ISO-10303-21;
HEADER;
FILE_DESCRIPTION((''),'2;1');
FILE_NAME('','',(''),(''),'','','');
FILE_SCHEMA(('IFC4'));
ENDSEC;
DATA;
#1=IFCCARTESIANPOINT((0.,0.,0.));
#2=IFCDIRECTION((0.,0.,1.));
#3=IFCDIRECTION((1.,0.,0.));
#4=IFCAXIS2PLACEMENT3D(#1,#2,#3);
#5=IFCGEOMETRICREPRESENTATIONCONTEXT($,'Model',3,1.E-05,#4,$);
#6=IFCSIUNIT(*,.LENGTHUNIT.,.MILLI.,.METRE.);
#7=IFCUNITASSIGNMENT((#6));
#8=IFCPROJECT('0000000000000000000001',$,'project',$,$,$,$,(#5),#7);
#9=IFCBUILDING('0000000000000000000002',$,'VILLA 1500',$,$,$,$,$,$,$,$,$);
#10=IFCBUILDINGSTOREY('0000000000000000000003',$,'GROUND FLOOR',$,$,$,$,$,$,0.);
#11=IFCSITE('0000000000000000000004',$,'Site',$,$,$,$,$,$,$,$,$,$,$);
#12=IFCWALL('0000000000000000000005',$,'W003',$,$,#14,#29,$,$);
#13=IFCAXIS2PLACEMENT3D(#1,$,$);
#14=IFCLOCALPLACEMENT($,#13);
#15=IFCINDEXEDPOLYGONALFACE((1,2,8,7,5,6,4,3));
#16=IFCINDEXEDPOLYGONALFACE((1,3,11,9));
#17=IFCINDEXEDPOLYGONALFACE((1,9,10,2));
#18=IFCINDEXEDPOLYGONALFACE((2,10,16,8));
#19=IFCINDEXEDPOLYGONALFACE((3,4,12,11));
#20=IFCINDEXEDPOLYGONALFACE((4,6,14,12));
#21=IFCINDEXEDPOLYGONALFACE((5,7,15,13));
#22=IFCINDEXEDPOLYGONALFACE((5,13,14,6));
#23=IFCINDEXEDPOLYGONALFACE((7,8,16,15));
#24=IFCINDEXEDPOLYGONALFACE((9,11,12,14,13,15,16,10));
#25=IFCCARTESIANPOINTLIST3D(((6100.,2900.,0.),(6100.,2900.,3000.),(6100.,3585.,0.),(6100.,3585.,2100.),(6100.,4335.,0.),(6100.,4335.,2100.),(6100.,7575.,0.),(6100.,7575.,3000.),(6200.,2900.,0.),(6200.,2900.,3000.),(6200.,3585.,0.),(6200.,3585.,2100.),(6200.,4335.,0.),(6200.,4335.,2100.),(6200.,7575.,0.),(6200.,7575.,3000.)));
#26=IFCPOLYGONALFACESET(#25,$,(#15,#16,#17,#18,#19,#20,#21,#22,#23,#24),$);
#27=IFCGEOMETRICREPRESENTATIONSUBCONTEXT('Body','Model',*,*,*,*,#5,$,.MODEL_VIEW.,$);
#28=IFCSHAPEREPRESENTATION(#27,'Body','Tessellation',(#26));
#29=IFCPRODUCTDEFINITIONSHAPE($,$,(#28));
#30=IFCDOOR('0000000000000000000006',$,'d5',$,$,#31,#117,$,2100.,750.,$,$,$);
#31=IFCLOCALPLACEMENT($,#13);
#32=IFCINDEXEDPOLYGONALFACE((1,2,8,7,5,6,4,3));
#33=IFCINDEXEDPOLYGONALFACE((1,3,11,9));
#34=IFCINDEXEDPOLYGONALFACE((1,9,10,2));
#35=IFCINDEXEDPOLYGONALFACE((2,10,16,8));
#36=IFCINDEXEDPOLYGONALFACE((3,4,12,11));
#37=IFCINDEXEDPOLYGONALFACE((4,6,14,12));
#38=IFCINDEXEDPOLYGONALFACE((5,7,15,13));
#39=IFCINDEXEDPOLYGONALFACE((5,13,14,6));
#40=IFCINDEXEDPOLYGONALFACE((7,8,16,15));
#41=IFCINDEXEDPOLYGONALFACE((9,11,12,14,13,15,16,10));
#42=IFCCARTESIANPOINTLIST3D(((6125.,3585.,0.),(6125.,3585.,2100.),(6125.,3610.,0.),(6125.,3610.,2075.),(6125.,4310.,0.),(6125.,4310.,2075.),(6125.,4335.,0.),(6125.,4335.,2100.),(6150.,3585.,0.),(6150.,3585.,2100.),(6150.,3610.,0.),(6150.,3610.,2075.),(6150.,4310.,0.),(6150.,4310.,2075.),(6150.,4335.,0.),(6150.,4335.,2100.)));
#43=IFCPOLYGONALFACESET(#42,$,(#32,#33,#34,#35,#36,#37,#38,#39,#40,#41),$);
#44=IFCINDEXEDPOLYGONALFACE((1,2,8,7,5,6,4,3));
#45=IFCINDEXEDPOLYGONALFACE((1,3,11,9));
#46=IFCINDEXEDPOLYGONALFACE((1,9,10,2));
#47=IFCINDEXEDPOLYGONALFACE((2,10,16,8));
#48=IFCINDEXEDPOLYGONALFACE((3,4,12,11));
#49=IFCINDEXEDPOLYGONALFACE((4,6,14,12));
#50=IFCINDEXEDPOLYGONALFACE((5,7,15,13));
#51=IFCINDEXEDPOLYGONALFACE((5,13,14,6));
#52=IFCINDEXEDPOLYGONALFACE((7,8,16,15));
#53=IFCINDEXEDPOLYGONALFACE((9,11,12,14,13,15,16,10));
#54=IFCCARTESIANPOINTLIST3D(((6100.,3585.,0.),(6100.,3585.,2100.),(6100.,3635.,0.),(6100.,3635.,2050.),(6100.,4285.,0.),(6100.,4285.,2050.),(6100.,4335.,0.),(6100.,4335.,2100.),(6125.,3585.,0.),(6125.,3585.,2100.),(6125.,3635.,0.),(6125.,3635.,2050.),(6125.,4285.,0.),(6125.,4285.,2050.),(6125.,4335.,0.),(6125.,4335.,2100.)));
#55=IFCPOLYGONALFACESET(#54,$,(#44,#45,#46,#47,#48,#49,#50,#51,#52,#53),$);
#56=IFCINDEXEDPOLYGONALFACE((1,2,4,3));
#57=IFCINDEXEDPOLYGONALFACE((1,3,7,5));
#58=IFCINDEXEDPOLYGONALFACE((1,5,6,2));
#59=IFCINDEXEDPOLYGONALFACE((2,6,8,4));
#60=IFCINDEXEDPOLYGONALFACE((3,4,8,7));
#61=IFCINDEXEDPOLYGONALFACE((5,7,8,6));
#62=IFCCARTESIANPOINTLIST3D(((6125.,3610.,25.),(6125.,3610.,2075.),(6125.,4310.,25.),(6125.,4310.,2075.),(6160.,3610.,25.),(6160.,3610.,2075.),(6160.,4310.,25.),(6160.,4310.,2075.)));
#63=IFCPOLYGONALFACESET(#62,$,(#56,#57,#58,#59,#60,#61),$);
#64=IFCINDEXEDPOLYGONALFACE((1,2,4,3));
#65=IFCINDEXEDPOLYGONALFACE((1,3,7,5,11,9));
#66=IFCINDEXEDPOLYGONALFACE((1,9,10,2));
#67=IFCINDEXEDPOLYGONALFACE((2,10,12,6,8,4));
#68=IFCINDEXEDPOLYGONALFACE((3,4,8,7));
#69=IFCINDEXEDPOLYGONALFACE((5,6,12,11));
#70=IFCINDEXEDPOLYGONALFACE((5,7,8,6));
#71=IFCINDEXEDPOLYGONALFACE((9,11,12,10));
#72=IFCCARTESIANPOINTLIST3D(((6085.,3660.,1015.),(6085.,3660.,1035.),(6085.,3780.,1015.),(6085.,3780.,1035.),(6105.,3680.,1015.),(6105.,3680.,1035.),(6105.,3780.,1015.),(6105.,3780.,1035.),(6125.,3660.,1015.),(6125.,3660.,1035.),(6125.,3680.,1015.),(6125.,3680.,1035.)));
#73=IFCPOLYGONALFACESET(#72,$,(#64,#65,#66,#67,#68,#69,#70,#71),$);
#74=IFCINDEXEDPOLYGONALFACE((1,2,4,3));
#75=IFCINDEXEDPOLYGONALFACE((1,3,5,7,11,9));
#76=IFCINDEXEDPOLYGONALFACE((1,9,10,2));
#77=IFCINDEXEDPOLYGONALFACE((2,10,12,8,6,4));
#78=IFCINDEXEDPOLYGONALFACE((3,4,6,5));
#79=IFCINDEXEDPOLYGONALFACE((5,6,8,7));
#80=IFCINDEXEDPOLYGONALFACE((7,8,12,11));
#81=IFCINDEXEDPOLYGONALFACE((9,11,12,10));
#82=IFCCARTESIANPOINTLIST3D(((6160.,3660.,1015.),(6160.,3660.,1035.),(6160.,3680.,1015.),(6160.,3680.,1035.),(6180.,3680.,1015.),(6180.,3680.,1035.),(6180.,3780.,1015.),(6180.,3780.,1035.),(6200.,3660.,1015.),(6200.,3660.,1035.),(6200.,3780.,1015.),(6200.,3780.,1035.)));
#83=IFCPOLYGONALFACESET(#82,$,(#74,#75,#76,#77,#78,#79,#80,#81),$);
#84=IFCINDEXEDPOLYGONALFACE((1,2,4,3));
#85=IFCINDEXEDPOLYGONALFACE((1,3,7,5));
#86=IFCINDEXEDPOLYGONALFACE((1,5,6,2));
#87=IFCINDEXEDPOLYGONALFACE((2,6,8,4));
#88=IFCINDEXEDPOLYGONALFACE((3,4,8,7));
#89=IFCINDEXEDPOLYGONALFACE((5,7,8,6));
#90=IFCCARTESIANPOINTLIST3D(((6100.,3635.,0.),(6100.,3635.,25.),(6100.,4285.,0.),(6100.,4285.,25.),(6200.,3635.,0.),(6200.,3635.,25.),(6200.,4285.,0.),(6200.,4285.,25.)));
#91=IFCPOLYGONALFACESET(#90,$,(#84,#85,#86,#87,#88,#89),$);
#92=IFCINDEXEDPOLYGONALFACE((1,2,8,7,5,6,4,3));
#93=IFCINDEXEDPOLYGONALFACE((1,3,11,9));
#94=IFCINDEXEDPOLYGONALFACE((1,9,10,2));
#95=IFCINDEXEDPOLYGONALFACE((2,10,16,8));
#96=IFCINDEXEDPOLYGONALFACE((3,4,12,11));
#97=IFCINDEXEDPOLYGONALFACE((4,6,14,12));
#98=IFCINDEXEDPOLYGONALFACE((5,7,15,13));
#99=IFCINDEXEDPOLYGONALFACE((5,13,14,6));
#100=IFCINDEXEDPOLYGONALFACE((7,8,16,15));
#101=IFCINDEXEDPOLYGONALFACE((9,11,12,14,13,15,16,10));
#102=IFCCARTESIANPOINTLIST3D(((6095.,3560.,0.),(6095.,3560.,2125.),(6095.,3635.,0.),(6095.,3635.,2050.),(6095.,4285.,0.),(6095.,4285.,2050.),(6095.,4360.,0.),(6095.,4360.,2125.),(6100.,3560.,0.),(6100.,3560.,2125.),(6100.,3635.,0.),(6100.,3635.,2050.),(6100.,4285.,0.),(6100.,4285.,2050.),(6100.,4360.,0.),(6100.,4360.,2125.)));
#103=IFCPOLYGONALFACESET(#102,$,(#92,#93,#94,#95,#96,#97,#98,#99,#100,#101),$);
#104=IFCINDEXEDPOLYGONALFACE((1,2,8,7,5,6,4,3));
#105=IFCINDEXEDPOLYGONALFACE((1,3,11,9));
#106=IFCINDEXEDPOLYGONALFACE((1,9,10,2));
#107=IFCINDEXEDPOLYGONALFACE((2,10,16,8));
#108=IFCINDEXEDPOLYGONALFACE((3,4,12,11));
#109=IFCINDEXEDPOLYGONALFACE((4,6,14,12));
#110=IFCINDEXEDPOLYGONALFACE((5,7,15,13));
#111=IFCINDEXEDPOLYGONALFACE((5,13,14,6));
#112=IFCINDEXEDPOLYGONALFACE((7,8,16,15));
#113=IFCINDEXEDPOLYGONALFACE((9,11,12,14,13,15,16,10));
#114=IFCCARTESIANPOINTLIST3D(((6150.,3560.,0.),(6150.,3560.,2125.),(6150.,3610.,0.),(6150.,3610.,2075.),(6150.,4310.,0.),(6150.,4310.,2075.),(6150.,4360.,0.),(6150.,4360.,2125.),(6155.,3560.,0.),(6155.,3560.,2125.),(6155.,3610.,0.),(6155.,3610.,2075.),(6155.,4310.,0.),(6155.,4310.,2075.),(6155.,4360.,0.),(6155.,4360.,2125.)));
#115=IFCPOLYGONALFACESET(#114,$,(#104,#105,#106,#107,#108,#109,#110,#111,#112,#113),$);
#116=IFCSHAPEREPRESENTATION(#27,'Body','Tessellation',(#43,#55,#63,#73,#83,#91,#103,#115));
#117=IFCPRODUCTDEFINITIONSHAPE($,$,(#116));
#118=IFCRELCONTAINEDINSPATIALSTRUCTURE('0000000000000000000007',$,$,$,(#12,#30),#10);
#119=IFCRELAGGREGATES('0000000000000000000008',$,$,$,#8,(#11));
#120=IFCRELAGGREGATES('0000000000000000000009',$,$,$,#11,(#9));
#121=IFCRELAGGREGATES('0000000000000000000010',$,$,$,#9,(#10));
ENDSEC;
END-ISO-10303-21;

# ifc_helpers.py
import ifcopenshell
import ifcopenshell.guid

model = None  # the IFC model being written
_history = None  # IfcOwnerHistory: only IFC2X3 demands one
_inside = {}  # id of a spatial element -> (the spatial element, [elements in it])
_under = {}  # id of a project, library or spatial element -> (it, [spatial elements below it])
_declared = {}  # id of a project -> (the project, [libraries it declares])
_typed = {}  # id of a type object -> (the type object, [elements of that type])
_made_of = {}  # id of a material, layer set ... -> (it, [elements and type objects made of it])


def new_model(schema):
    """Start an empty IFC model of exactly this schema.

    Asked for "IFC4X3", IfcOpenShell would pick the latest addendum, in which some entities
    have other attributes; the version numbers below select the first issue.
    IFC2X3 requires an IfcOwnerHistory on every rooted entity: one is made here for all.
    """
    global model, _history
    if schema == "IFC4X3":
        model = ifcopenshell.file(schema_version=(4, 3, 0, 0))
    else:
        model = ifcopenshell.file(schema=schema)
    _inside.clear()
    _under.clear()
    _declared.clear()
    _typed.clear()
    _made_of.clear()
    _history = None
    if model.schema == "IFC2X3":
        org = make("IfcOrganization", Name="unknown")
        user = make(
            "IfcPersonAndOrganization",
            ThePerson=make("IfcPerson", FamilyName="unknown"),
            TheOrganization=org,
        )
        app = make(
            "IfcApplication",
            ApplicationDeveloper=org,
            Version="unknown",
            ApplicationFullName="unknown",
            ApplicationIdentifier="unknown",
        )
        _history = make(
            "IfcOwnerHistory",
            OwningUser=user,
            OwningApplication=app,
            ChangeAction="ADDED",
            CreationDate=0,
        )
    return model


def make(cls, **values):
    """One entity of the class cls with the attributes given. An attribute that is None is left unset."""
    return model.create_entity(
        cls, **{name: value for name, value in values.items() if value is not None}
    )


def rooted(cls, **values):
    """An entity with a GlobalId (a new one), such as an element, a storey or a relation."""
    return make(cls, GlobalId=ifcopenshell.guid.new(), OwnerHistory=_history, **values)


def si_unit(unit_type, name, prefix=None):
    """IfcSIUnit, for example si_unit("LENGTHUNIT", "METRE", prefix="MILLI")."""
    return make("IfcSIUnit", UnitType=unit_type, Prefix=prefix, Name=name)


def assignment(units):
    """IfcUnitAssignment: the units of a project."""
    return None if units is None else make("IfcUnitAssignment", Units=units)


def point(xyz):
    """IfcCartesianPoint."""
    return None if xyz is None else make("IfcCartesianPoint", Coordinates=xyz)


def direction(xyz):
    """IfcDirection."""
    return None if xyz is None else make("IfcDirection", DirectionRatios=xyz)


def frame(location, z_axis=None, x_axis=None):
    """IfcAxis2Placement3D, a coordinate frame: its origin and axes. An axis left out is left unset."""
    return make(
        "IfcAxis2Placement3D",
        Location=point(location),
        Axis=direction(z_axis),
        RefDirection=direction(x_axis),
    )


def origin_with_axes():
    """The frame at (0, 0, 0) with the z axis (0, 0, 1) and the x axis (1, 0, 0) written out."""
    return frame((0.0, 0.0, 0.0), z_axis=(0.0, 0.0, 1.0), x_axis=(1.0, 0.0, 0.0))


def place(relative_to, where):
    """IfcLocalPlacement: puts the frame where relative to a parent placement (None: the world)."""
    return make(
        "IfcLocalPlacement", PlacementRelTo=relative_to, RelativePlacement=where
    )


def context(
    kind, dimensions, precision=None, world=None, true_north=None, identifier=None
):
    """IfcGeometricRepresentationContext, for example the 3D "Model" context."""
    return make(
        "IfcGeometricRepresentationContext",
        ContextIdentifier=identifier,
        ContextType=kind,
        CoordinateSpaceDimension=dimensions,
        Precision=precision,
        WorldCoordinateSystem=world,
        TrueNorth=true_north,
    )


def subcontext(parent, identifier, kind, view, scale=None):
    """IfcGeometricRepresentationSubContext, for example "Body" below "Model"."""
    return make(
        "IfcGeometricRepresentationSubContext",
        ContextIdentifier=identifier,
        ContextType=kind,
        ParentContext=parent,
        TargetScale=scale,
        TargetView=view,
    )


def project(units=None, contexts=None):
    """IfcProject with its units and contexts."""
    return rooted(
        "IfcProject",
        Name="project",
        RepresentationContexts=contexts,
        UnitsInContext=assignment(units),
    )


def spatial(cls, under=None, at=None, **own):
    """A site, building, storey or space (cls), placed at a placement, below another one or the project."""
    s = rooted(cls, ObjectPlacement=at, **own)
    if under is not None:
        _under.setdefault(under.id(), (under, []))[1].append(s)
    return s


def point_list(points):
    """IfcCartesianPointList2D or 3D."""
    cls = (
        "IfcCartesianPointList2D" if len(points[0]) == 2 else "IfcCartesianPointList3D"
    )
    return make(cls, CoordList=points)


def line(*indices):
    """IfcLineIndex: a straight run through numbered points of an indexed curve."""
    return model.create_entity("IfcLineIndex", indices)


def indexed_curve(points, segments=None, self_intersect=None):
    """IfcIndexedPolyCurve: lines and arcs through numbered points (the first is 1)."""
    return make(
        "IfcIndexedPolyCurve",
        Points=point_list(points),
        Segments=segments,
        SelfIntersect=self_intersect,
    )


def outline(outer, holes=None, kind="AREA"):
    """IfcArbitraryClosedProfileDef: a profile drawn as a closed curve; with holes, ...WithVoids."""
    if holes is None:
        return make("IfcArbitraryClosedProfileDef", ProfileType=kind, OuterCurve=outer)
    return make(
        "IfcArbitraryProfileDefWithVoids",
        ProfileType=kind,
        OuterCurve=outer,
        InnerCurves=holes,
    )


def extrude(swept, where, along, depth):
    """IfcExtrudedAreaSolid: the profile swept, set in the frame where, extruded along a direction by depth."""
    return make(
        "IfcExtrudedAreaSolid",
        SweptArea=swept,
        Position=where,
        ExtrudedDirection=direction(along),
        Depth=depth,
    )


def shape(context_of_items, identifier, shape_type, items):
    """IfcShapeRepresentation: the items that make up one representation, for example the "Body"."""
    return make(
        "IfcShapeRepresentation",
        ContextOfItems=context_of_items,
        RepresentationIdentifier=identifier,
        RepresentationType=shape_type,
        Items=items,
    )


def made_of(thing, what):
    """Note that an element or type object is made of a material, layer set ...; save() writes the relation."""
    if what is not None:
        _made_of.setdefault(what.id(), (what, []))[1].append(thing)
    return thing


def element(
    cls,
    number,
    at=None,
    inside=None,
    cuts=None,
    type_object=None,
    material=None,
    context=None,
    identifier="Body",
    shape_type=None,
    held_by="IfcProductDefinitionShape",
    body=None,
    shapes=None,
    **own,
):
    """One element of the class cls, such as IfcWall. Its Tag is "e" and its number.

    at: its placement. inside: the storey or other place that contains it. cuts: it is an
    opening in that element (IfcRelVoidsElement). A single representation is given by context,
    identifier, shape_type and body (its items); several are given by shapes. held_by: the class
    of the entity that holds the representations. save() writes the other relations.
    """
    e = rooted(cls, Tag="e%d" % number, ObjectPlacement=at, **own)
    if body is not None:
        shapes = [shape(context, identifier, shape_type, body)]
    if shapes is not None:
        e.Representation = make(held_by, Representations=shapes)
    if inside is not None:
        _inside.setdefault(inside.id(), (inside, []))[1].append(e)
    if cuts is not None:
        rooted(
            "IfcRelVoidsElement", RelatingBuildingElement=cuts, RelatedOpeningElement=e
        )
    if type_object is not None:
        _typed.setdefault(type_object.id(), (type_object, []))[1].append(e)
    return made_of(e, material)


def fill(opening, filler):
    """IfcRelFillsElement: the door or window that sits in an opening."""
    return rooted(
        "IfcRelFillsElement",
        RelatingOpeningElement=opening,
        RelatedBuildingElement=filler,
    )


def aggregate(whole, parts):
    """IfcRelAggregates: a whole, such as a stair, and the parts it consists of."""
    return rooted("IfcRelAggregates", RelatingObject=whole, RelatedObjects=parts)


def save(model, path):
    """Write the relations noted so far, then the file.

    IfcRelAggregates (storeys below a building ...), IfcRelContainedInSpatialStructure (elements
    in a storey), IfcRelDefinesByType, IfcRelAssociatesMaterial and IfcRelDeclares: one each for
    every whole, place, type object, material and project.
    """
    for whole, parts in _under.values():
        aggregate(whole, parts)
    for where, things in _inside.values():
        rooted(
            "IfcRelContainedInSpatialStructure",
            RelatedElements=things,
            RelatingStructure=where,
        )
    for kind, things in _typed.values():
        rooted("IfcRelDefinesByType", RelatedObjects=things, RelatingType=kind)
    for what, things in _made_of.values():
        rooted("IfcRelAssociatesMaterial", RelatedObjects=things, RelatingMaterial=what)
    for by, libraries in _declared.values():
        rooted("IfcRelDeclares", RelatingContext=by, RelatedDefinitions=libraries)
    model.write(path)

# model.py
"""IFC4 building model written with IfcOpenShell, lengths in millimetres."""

from ifc_helpers import new_model, si_unit, frame, origin_with_axes, place, context, subcontext, project, spatial, line, indexed_curve, outline, extrude, element, fill, save


model = new_model("IFC4")

# Units and contexts
model_context = context("Model", 3, precision=1e-05, world=origin_with_axes())
body_context = subcontext(model_context, "Body", "Model", "MODEL_VIEW")
ifc_project = project(units=[si_unit("LENGTHUNIT", "METRE", prefix="MILLI")], contexts=[model_context])

# Site, building, storey
site = spatial("IfcSite", under=ifc_project, Name="Site")
building = spatial("IfcBuilding", under=site, Name="VILLA 1500")
storey = spatial("IfcBuildingStorey", under=building, Name="GROUND FLOOR", Elevation=0.0)

# Wall, opening, door
wall_1_placement = place(None, frame((6150.0, 7575.0, 0.0), z_axis=(0.0, 0.0, 1.0), x_axis=(0.0, -1.0, 0.0)))
wall_1 = element("IfcWall", 1, at=wall_1_placement, inside=storey, Name="W003", context=body_context, shape_type="SweptSolid", body=[
    extrude(outline(indexed_curve([(0.0, 0.0), (0.0, 100.0), (4675.0, 100.0), (4675.0, 0.0), (0.0, 0.0)], self_intersect=False)), frame((0.0, -50.0, 0.0), z_axis=(0.0, 0.0, 1.0), x_axis=(1.0, 0.0, 0.0)), (0.0, 0.0, 1.0), 3000.0),
])
opening_1_placement = place(wall_1_placement, frame((3240.0, 0.0, 0.0), z_axis=(0.0, 0.0, 1.0), x_axis=(1.0, 0.0, 0.0)))
opening_1 = element("IfcOpeningElement", 2, at=opening_1_placement, cuts=wall_1, context=body_context, shape_type="SweptSolid", body=[
    extrude(outline(indexed_curve([(0.0, 0.0), (0.0, 200.0), (750.0, 200.0), (750.0, 0.0), (0.0, 0.0)], self_intersect=False)), frame((0.0, -100.0, 0.0), z_axis=(0.0, 0.0, 1.0), x_axis=(1.0, 0.0, 0.0)), (0.0, 0.0, 1.0), 2100.0),
])
door_1_placement = place(None, frame((6100.0, 4335.0, 0.0), z_axis=(0.0, 0.0, 1.0), x_axis=(0.0, -1.0, 0.0)))
door_1 = element("IfcDoor", 3, at=door_1_placement, inside=storey, Name="d5", OverallHeight=2100.0, OverallWidth=750.0, context=body_context, shape_type="SweptSolid", body=[
    extrude(outline(indexed_curve([(0.0, 0.0), (0.0, 2100.0), (750.0, 2100.0), (750.0, 0.0), (725.0, 0.0), (725.0, 2075.0), (25.0, 2075.0), (25.0, 0.0)], segments=[line(1, 2, 3, 4, 5, 6, 7, 8, 1)])), frame((0.0, 25.0, 0.0), z_axis=(0.0, -1.0, 0.0), x_axis=(1.0, 0.0, 0.0)), (0.0, 0.0, -1.0), 25.0),
    extrude(outline(indexed_curve([(0.0, 0.0), (0.0, 2100.0), (750.0, 2100.0), (750.0, 0.0), (700.0, 0.0), (700.0, 2050.0), (50.0, 2050.0), (50.0, 0.0)], segments=[line(1, 2, 3, 4, 5, 6, 7, 8, 1)])), frame((0.0, 0.0, 0.0), z_axis=(0.0, -1.0, 0.0), x_axis=(1.0, 0.0, 0.0)), (0.0, 0.0, -1.0), 25.0),
    extrude(outline(indexed_curve([(0.0, 0.0), (700.0, 0.0), (700.0, 35.0), (0.0, 35.0)], segments=[line(1, 2, 3, 4, 1)])), frame((25.0, 25.0, 25.0), z_axis=(0.0, 0.0, 1.0), x_axis=(1.0, 0.0, 0.0)), (0.0, 0.0, 1.0), 2050.0),
    extrude(outline(indexed_curve([(0.0, 0.0), (0.0, -40.0), (-120.0, -40.0), (-120.0, -20.0), (-20.0, -20.0), (-20.0, 0.0)], segments=[line(1, 2, 3, 4, 5, 6, 1)])), frame((675.0, 25.0, 1015.0), z_axis=(0.0, 0.0, 1.0), x_axis=(1.0, 0.0, 0.0)), (0.0, 0.0, 1.0), 20.0),
    extrude(outline(indexed_curve([(0.0, 0.0), (0.0, 40.0), (-120.0, 40.0), (-120.0, 20.0), (-20.0, 20.0), (-20.0, 0.0)], segments=[line(1, 2, 3, 4, 5, 6, 1)])), frame((675.0, 60.0, 1015.0), z_axis=(0.0, 0.0, 1.0), x_axis=(1.0, 0.0, 0.0)), (0.0, 0.0, 1.0), 20.0),
    extrude(outline(indexed_curve([(0.0, 0.0), (650.0, 0.0), (650.0, 100.0), (0.0, 100.0)], segments=[line(1, 2, 3, 4, 1)])), frame((50.0, 0.0, 0.0), z_axis=(0.0, 0.0, 1.0), x_axis=(1.0, 0.0, 0.0)), (0.0, 0.0, 1.0), 25.0),
    extrude(outline(indexed_curve([(0.0, 0.0), (0.0, 2125.0), (800.0, 2125.0), (800.0, 0.0), (725.0, 0.0), (725.0, 2050.0), (75.0, 2050.0), (75.0, 0.0)], segments=[line(1, 2, 3, 4, 5, 6, 7, 8, 1)])), frame((-25.0, -5.0, 0.0), z_axis=(0.0, -1.0, 0.0), x_axis=(1.0, 0.0, 0.0)), (0.0, 0.0, -1.0), 5.0),
    extrude(outline(indexed_curve([(0.0, 0.0), (0.0, 2125.0), (800.0, 2125.0), (800.0, 0.0), (750.0, 0.0), (750.0, 2075.0), (50.0, 2075.0), (50.0, 0.0)], segments=[line(1, 2, 3, 4, 5, 6, 7, 8, 1)])), frame((-25.0, 50.0, 0.0), z_axis=(0.0, -1.0, 0.0), x_axis=(1.0, 0.0, 0.0)), (0.0, 0.0, -1.0), 5.0),
])
fill(opening_1, door_1)

save(model, "model.ifc")
